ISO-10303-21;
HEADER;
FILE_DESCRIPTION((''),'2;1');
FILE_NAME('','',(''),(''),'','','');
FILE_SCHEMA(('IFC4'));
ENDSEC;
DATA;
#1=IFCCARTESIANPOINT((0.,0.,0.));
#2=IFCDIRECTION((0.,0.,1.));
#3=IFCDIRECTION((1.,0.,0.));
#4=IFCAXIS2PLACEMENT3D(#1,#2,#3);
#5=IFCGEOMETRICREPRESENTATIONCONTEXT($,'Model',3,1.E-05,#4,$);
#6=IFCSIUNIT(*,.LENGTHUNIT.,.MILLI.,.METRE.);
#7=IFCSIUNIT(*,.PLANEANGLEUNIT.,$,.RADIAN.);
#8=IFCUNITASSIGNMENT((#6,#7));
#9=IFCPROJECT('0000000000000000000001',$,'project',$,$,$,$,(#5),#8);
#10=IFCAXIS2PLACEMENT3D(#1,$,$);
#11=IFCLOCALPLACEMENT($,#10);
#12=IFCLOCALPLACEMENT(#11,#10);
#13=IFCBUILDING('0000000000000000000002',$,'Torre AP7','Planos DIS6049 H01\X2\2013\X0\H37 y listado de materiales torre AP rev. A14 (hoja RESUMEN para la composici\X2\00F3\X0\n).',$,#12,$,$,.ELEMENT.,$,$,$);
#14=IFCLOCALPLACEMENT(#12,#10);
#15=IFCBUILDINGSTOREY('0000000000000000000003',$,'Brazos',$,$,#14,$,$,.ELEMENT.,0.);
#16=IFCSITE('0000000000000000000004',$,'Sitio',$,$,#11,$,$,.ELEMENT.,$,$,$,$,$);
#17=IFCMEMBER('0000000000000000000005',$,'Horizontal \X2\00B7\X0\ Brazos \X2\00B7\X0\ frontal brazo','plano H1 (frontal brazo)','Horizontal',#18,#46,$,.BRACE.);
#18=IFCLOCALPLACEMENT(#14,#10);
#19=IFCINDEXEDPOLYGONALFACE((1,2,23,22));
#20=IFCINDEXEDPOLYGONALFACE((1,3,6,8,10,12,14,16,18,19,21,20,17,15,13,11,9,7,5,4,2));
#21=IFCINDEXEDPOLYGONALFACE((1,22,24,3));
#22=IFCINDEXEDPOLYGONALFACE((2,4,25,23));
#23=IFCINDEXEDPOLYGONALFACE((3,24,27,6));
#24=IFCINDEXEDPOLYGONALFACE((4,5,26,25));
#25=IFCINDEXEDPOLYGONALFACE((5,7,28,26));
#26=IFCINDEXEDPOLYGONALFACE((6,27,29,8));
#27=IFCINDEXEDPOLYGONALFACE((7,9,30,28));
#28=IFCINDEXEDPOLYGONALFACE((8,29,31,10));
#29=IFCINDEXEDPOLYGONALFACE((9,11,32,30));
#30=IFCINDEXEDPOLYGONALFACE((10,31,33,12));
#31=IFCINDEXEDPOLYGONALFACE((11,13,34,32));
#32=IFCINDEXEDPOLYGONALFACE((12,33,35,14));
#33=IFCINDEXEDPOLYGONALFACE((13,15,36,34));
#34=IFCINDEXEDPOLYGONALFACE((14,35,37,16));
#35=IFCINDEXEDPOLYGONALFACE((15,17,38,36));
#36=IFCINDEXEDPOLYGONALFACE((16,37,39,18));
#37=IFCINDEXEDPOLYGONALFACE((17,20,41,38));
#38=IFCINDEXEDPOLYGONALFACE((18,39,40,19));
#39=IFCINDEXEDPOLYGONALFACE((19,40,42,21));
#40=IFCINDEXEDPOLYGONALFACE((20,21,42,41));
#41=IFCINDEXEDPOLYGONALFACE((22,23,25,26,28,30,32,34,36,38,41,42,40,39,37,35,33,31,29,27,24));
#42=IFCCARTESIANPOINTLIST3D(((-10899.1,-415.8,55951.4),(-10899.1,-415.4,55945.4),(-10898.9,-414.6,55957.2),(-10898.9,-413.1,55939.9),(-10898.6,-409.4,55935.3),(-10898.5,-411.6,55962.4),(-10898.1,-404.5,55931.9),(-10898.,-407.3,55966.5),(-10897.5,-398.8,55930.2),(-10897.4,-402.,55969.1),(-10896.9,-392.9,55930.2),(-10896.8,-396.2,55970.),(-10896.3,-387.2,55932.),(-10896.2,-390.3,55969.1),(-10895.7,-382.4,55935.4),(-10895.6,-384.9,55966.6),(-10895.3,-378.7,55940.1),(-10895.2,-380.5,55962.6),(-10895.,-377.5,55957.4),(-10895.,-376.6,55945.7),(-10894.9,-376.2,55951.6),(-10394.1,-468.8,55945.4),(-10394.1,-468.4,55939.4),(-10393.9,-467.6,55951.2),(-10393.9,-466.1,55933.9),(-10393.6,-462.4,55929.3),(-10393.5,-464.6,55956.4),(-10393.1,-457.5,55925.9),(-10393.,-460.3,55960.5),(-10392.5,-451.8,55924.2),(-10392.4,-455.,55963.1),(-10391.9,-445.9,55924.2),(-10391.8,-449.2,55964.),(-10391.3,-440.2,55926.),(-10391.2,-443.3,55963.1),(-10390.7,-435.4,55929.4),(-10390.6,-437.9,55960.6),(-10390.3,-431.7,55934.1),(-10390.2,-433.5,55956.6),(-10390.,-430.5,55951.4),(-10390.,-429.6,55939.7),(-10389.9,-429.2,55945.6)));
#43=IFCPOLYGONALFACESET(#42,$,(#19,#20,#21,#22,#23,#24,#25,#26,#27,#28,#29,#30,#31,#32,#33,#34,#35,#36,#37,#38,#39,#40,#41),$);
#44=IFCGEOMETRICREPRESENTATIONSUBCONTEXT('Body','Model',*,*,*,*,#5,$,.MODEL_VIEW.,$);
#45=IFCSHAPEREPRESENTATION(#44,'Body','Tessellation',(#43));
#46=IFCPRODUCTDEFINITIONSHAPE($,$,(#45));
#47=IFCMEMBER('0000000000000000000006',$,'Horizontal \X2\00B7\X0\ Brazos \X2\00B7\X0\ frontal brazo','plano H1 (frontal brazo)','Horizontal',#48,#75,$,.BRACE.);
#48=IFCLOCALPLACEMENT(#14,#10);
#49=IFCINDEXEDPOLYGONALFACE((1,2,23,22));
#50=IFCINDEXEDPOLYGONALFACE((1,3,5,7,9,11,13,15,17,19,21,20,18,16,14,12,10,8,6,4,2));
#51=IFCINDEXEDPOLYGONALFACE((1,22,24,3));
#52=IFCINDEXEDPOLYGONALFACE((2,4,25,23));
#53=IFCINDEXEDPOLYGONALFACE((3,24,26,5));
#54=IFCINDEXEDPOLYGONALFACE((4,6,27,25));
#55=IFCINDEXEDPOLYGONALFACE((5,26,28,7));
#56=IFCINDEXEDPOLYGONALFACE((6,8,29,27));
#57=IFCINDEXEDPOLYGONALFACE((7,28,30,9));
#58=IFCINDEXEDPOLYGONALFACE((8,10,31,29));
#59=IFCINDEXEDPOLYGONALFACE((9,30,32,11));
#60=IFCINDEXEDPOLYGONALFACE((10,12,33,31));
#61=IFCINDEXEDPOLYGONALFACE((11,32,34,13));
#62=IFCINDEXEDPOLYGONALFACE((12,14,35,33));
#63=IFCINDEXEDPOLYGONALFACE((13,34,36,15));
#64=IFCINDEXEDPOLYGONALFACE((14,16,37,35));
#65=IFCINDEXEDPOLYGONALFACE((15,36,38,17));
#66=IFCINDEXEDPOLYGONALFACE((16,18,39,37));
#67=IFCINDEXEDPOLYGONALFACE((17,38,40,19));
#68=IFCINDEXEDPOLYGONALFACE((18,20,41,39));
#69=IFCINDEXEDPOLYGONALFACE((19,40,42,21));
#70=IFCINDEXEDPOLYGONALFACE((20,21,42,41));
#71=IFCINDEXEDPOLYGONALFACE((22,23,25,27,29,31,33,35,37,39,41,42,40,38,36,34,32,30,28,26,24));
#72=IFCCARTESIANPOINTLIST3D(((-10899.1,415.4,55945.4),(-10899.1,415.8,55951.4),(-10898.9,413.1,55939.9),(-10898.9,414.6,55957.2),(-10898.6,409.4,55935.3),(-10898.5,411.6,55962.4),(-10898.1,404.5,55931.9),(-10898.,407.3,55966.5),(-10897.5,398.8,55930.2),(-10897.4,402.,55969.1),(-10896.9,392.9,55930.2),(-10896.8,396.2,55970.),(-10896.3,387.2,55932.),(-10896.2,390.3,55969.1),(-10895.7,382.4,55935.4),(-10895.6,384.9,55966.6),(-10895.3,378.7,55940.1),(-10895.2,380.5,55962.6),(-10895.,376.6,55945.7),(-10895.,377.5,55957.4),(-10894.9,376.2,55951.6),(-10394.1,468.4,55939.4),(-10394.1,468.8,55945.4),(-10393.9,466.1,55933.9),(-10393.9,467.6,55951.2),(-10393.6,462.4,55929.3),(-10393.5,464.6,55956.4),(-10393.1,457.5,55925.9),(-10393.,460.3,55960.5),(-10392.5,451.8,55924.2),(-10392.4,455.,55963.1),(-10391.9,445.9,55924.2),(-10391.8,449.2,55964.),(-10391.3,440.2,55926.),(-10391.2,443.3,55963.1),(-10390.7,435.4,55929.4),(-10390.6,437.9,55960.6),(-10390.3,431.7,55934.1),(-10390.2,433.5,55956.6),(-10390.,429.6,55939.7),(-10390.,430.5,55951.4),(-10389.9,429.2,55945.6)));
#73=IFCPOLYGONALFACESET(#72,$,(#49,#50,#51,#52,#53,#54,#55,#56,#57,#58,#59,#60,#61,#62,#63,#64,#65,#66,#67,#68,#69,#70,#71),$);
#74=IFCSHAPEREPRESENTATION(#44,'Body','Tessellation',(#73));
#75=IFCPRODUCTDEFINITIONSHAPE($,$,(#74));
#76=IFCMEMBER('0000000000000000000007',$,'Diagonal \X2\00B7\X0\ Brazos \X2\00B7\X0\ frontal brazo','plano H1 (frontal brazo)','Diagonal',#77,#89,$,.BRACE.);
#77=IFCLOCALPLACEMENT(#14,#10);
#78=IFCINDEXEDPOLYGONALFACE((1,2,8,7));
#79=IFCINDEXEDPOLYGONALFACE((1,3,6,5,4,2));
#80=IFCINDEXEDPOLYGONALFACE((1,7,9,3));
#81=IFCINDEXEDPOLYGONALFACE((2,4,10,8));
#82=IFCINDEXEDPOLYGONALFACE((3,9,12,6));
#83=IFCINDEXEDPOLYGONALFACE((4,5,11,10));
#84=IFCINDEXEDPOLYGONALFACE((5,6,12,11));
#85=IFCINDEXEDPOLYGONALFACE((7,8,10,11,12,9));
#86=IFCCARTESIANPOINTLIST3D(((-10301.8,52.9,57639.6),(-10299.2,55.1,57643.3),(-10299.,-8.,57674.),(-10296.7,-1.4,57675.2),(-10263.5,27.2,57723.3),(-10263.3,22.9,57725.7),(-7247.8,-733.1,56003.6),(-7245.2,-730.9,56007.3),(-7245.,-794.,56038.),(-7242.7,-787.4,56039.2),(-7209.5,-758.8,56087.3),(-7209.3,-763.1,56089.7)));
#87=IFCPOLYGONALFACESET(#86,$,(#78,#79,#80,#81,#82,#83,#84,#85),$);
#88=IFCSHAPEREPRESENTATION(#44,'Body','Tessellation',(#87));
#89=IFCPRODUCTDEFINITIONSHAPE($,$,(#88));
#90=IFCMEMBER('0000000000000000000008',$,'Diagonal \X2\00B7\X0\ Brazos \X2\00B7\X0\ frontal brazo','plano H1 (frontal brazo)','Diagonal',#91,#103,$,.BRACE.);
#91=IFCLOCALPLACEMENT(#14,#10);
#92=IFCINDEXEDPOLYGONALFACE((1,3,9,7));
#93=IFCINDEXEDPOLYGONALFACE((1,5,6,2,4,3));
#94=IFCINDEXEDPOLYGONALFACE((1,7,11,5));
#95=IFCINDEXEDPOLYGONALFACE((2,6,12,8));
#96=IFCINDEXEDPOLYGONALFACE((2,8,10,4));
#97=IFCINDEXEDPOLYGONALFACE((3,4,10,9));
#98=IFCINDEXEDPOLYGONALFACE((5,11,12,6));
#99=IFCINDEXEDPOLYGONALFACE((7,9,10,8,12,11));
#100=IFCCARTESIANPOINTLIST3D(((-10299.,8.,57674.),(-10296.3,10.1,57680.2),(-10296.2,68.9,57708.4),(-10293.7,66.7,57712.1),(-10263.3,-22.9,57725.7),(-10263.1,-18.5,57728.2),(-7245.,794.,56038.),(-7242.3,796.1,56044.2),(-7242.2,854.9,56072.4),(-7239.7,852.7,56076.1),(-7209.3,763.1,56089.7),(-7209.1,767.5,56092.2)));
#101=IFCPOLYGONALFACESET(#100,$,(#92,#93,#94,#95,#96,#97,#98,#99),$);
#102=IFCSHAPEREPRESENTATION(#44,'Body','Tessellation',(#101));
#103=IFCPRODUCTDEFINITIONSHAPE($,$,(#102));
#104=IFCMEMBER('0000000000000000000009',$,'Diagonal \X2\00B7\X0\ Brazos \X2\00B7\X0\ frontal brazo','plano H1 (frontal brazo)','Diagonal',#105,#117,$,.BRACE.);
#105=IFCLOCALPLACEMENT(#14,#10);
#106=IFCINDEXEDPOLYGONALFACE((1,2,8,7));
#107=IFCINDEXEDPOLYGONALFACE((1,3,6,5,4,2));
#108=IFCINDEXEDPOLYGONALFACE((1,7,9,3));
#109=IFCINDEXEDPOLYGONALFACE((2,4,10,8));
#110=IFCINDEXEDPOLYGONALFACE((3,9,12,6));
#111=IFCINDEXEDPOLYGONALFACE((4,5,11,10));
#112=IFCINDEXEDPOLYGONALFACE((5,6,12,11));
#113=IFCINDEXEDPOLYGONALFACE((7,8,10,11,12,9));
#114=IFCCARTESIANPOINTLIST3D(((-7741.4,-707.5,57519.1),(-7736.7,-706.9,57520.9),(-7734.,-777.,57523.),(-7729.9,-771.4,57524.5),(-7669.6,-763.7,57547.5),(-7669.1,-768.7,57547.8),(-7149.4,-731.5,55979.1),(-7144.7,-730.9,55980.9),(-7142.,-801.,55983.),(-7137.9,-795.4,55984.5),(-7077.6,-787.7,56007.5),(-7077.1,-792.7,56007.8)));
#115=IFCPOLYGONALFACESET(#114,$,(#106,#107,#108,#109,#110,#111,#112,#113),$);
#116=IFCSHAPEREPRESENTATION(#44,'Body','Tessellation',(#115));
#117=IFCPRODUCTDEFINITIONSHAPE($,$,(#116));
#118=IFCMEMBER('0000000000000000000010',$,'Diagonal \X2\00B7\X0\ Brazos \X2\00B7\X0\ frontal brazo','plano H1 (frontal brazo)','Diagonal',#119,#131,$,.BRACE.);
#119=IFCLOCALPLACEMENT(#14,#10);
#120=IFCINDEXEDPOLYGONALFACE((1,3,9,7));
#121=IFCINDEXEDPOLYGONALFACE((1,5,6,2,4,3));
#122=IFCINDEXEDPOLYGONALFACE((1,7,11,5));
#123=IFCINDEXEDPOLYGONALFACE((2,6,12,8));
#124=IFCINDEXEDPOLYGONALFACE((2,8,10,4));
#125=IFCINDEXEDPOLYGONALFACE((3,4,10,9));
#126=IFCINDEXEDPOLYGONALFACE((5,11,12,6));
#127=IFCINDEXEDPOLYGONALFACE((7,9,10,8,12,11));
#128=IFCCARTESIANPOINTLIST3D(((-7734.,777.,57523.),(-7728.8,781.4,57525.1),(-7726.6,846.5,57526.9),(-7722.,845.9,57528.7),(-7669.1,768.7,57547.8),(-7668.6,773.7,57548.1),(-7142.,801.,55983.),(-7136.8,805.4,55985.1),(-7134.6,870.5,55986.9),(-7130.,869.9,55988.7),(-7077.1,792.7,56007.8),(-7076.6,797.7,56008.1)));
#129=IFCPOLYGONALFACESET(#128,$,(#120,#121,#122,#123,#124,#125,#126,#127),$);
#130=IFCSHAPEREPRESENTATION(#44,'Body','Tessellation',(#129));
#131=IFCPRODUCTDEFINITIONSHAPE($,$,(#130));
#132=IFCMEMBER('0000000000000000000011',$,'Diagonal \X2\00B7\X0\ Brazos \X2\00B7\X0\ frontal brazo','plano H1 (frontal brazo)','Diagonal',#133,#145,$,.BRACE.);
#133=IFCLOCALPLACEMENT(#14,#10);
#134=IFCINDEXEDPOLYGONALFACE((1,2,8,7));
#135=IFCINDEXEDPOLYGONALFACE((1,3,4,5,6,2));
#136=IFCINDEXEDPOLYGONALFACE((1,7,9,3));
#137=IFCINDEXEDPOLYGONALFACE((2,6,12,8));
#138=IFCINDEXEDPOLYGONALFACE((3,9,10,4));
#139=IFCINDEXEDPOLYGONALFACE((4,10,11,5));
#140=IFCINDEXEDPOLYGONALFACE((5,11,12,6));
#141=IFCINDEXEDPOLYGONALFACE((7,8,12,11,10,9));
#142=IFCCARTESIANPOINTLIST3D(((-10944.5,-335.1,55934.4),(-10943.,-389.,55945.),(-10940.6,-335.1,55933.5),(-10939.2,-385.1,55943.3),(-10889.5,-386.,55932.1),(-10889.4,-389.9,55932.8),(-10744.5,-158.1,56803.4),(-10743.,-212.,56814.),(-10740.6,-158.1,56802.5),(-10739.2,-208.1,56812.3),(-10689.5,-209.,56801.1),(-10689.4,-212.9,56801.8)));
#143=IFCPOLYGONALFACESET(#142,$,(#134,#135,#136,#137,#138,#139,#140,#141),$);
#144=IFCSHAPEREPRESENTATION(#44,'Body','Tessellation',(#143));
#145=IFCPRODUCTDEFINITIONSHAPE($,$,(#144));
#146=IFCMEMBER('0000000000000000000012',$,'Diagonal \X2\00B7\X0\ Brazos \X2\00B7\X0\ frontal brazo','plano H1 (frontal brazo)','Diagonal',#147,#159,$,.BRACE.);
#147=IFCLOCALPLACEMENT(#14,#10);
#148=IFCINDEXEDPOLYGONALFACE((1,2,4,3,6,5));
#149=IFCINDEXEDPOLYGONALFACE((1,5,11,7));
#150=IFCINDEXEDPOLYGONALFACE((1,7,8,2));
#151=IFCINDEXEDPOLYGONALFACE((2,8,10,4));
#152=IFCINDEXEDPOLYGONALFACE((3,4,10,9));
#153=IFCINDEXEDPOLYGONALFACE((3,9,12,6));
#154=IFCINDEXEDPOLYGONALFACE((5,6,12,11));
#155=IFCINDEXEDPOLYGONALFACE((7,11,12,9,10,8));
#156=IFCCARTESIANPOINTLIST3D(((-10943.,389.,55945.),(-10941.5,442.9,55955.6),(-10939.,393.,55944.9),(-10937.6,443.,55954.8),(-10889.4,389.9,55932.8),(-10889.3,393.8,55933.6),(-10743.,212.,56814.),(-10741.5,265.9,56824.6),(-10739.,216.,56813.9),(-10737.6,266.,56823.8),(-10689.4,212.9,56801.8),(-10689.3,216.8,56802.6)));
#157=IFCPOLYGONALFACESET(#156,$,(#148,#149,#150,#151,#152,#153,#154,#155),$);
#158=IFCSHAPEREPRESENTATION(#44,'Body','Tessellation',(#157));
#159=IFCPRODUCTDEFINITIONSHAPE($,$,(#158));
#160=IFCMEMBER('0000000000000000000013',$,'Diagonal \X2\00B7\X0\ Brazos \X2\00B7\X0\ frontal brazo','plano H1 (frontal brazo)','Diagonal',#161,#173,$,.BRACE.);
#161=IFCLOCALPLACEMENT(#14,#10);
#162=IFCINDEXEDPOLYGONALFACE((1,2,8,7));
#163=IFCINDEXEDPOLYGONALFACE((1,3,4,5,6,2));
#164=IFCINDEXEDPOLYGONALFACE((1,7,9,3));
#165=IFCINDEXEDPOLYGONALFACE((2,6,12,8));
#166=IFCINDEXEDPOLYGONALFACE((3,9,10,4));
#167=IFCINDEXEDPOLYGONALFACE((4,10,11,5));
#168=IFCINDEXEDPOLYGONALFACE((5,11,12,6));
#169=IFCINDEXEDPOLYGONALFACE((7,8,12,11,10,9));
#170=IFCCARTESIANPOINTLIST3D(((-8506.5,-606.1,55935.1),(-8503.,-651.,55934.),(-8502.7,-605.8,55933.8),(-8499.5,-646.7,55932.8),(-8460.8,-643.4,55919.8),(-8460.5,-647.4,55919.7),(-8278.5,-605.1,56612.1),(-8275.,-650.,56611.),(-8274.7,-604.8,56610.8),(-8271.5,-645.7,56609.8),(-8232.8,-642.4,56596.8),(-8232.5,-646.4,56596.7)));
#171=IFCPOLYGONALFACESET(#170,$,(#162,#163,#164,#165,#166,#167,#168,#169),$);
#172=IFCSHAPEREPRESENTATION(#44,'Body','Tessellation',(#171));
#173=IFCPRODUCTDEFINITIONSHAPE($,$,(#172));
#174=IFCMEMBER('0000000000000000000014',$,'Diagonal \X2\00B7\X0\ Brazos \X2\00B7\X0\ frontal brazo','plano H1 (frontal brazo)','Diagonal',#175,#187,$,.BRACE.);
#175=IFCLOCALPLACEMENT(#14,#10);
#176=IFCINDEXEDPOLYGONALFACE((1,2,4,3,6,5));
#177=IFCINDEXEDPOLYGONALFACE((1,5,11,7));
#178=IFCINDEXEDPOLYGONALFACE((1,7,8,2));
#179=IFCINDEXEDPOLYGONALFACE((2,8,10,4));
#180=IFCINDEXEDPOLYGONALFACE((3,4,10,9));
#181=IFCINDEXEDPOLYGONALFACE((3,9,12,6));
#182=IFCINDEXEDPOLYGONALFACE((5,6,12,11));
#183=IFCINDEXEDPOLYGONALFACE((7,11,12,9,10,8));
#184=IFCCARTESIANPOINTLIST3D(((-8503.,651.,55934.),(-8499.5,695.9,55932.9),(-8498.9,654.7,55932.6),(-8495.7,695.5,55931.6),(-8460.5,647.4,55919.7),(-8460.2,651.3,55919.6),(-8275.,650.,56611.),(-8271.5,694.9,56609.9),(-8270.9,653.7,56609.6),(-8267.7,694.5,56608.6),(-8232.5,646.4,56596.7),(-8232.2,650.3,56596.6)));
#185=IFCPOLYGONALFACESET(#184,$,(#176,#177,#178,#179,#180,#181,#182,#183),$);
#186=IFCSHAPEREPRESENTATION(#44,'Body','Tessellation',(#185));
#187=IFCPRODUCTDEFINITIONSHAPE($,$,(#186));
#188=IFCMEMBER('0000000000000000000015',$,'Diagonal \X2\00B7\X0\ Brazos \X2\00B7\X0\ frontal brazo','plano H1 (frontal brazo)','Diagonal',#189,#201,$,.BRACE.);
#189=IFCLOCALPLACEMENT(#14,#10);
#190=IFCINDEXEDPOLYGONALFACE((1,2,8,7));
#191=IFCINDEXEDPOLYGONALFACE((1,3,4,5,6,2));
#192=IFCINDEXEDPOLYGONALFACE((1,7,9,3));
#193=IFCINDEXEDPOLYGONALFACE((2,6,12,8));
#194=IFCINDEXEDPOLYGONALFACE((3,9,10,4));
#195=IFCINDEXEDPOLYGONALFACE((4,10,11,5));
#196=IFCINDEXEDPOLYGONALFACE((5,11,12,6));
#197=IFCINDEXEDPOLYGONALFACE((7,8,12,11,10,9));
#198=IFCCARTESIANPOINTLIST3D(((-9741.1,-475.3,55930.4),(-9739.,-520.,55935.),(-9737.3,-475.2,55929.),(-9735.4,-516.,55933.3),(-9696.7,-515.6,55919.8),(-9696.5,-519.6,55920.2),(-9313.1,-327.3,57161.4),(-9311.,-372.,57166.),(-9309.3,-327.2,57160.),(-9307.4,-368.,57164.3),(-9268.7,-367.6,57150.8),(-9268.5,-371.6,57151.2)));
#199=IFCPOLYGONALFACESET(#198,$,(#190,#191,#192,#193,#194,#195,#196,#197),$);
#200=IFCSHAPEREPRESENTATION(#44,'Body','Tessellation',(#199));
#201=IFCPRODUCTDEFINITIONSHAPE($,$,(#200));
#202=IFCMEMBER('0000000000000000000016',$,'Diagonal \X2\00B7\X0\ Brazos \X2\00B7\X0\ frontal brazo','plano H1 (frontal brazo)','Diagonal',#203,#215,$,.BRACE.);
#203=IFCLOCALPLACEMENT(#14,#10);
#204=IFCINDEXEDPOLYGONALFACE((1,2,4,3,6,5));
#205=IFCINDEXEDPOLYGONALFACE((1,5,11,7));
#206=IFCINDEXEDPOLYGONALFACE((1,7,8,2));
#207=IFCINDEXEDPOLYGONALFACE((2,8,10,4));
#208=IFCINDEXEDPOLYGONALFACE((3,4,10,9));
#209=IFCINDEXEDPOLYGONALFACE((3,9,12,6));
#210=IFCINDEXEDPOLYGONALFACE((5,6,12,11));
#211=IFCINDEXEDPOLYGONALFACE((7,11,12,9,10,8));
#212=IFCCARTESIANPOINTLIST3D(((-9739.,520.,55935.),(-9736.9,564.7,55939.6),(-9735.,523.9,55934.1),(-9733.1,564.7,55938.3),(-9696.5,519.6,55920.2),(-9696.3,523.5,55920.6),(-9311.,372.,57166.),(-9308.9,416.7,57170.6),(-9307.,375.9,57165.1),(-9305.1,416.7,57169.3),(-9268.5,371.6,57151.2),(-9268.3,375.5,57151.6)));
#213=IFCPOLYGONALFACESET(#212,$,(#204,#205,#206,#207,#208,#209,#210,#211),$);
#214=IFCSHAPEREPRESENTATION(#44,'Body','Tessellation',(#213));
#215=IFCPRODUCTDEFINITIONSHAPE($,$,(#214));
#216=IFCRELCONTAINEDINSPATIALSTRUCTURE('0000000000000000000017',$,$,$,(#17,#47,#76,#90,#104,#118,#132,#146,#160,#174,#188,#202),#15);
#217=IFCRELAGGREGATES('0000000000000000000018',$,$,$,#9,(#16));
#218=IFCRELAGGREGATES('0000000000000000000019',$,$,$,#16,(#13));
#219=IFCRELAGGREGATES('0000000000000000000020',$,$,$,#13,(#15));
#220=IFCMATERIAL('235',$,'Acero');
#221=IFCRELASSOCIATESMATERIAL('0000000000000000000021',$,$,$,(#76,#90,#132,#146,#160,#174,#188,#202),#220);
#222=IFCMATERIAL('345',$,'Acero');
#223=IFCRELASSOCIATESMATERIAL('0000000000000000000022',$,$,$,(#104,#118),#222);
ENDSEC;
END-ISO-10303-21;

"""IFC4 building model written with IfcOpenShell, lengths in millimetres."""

from ifc_helpers import new_model, si_unit, frame, frame_2d, origin, origin_with_axes, place, context, subcontext, project, spatial, circle, l_section, extrude, material, element, save


model = new_model("IFC4")

# Units and contexts
model_context = context("Model", 3, precision=1e-05, world=origin_with_axes())
body_context = subcontext(model_context, "Body", "Model", "MODEL_VIEW")
ifc_project = project(units=[si_unit("LENGTHUNIT", "METRE", prefix="MILLI"), si_unit("PLANEANGLEUNIT", "RADIAN")], contexts=[model_context])

# Site, building, storey
site_placement = place(None, origin())
site = spatial("IfcSite", under=ifc_project, at=site_placement, Name="Sitio", CompositionType="ELEMENT")
building_placement = place(site_placement, origin())
building = spatial("IfcBuilding", under=site, at=building_placement, Name="Torre AP7", Description="Planos DIS6049 H01–H37 y listado de materiales torre AP rev. A14 (hoja RESUMEN para la composición).", CompositionType="ELEMENT")
storey_placement = place(building_placement, origin())
storey = spatial("IfcBuildingStorey", under=building, at=storey_placement, Name="Brazos", CompositionType="ELEMENT", Elevation=0.0)

# Members
for number, where, z_axis, x_axis, name in (
    (1, (-10392.0, -449.0, 55944.0), (-0.994468, 0.10437, 0.011815), (0.104986, 0.991163, 0.081074), "Horizontal · Brazos · frontal brazo"),
    (2, (-10392.0, 449.0, 55944.0), (-0.994468, -0.10437, 0.011815), (0.104986, -0.991163, 0.081074), "Horizontal · Brazos · frontal brazo"),
):
    element("IfcMember", number, at=place(storey_placement, frame(where, z_axis=z_axis, x_axis=x_axis)), inside=storey, Name=name, Description="plano H1 (frontal brazo)", ObjectType="Horizontal", PredefinedType="BRACE", context=body_context, shape_type="SweptSolid", body=[
        extrude(circle(Radius=20.0), None, (0.0, 0.0, 1.0), 507.8),
    ])
ifc_material_1 = material(Name="235", Category="Acero")
for number, where, z_axis, x_axis, name in (
    (3, (-7245.0, -794.0, 56038.0), (-0.859644, 0.221244, 0.460503), (0.509345, 0.441284, 0.738808), "Diagonal · Brazos · frontal brazo"),
    (4, (-7245.0, 794.0, 56038.0), (-0.859644, -0.221244, 0.460503), (0.509345, -0.441284, 0.738808), "Diagonal · Brazos · frontal brazo"),
):
    element("IfcMember", number, at=place(storey_placement, frame(where, z_axis=z_axis, x_axis=x_axis)), inside=storey, material=ifc_material_1, Name=name, Description="plano H1 (frontal brazo)", ObjectType="Diagonal", PredefinedType="BRACE", context=body_context, shape_type="SweptSolid", body=[
        extrude(l_section(Depth=70.0, Width=70.0, Thickness=5.0, at=frame_2d((35.0, 35.0))), None, (0.0, 0.0, 1.0), 3552.6),
    ])
ifc_material_2 = material(Name="345", Category="Acero")
for number, where, z_axis, x_axis, name in (
    (5, (-7142.0, -801.0, 55983.0), (-0.358779, 0.014545, 0.933309), (0.927462, 0.118373, 0.354686), "Diagonal · Brazos · frontal brazo"),
    (6, (-7142.0, 801.0, 55983.0), (-0.358779, -0.014545, 0.933309), (0.927462, -0.118373, 0.354686), "Diagonal · Brazos · frontal brazo"),
):
    element("IfcMember", number, at=place(storey_placement, frame(where, z_axis=z_axis, x_axis=x_axis)), inside=storey, material=ifc_material_2, Name=name, Description="plano H1 (frontal brazo)", ObjectType="Diagonal", PredefinedType="BRACE", context=body_context, shape_type="SweptSolid", body=[
        extrude(l_section(Depth=70.0, Width=70.0, Thickness=5.0, at=frame_2d((35.0, 35.0))), None, (0.0, 0.0, 1.0), 1650.0),
    ])
for number, where, z_axis, x_axis, name in (
    (7, (-10943.0, -389.0, 55945.0), (0.219994, 0.194695, 0.955875), (0.975122, -0.016589, -0.221045), "Diagonal · Brazos · frontal brazo"),
    (8, (-10943.0, 389.0, 55945.0), (0.219994, -0.194695, 0.955875), (0.975122, 0.016589, -0.221045), "Diagonal · Brazos · frontal brazo"),
):
    element("IfcMember", number, at=place(storey_placement, frame(where, z_axis=z_axis, x_axis=x_axis)), inside=storey, material=ifc_material_1, Name=name, Description="plano H1 (frontal brazo)", ObjectType="Diagonal", PredefinedType="BRACE", context=body_context, shape_type="SweptSolid", body=[
        extrude(l_section(Depth=55.0, Width=55.0, Thickness=4.0, at=frame_2d((27.5, 27.5))), None, (0.0, 0.0, 1.0), 909.1),
    ])
for number, where, z_axis, x_axis, name in (
    (9, (-8503.0, -651.0, 55934.0), (0.319166, 0.0014, 0.947698), (0.944542, 0.081082, -0.318223), "Diagonal · Brazos · frontal brazo"),
    (10, (-8503.0, 651.0, 55934.0), (0.319166, -0.0014, 0.947698), (0.944542, -0.081082, -0.318223), "Diagonal · Brazos · frontal brazo"),
):
    element("IfcMember", number, at=place(storey_placement, frame(where, z_axis=z_axis, x_axis=x_axis)), inside=storey, material=ifc_material_1, Name=name, Description="plano H1 (frontal brazo)", ObjectType="Diagonal", PredefinedType="BRACE", context=body_context, shape_type="SweptSolid", body=[
        extrude(l_section(Depth=45.0, Width=45.0, Thickness=4.0, at=frame_2d((22.5, 22.5))), None, (0.0, 0.0, 1.0), 714.4),
    ])
for number, where, z_axis, x_axis, name in (
    (11, (-9739.0, -520.0, 55935.0), (0.326304, 0.112834, 0.938506), (0.944119, 0.009962, -0.329454), "Diagonal · Brazos · frontal brazo"),
    (12, (-9739.0, 520.0, 55935.0), (0.326304, -0.112834, 0.938506), (0.944119, -0.009962, -0.329454), "Diagonal · Brazos · frontal brazo"),
):
    element("IfcMember", number, at=place(storey_placement, frame(where, z_axis=z_axis, x_axis=x_axis)), inside=storey, material=ifc_material_1, Name=name, Description="plano H1 (frontal brazo)", ObjectType="Diagonal", PredefinedType="BRACE", context=body_context, shape_type="SweptSolid", body=[
        extrude(l_section(Depth=45.0, Width=45.0, Thickness=4.0, at=frame_2d((22.5, 22.5))), None, (0.0, 0.0, 1.0), 1311.7),
    ])

save(model, "model.ifc")
